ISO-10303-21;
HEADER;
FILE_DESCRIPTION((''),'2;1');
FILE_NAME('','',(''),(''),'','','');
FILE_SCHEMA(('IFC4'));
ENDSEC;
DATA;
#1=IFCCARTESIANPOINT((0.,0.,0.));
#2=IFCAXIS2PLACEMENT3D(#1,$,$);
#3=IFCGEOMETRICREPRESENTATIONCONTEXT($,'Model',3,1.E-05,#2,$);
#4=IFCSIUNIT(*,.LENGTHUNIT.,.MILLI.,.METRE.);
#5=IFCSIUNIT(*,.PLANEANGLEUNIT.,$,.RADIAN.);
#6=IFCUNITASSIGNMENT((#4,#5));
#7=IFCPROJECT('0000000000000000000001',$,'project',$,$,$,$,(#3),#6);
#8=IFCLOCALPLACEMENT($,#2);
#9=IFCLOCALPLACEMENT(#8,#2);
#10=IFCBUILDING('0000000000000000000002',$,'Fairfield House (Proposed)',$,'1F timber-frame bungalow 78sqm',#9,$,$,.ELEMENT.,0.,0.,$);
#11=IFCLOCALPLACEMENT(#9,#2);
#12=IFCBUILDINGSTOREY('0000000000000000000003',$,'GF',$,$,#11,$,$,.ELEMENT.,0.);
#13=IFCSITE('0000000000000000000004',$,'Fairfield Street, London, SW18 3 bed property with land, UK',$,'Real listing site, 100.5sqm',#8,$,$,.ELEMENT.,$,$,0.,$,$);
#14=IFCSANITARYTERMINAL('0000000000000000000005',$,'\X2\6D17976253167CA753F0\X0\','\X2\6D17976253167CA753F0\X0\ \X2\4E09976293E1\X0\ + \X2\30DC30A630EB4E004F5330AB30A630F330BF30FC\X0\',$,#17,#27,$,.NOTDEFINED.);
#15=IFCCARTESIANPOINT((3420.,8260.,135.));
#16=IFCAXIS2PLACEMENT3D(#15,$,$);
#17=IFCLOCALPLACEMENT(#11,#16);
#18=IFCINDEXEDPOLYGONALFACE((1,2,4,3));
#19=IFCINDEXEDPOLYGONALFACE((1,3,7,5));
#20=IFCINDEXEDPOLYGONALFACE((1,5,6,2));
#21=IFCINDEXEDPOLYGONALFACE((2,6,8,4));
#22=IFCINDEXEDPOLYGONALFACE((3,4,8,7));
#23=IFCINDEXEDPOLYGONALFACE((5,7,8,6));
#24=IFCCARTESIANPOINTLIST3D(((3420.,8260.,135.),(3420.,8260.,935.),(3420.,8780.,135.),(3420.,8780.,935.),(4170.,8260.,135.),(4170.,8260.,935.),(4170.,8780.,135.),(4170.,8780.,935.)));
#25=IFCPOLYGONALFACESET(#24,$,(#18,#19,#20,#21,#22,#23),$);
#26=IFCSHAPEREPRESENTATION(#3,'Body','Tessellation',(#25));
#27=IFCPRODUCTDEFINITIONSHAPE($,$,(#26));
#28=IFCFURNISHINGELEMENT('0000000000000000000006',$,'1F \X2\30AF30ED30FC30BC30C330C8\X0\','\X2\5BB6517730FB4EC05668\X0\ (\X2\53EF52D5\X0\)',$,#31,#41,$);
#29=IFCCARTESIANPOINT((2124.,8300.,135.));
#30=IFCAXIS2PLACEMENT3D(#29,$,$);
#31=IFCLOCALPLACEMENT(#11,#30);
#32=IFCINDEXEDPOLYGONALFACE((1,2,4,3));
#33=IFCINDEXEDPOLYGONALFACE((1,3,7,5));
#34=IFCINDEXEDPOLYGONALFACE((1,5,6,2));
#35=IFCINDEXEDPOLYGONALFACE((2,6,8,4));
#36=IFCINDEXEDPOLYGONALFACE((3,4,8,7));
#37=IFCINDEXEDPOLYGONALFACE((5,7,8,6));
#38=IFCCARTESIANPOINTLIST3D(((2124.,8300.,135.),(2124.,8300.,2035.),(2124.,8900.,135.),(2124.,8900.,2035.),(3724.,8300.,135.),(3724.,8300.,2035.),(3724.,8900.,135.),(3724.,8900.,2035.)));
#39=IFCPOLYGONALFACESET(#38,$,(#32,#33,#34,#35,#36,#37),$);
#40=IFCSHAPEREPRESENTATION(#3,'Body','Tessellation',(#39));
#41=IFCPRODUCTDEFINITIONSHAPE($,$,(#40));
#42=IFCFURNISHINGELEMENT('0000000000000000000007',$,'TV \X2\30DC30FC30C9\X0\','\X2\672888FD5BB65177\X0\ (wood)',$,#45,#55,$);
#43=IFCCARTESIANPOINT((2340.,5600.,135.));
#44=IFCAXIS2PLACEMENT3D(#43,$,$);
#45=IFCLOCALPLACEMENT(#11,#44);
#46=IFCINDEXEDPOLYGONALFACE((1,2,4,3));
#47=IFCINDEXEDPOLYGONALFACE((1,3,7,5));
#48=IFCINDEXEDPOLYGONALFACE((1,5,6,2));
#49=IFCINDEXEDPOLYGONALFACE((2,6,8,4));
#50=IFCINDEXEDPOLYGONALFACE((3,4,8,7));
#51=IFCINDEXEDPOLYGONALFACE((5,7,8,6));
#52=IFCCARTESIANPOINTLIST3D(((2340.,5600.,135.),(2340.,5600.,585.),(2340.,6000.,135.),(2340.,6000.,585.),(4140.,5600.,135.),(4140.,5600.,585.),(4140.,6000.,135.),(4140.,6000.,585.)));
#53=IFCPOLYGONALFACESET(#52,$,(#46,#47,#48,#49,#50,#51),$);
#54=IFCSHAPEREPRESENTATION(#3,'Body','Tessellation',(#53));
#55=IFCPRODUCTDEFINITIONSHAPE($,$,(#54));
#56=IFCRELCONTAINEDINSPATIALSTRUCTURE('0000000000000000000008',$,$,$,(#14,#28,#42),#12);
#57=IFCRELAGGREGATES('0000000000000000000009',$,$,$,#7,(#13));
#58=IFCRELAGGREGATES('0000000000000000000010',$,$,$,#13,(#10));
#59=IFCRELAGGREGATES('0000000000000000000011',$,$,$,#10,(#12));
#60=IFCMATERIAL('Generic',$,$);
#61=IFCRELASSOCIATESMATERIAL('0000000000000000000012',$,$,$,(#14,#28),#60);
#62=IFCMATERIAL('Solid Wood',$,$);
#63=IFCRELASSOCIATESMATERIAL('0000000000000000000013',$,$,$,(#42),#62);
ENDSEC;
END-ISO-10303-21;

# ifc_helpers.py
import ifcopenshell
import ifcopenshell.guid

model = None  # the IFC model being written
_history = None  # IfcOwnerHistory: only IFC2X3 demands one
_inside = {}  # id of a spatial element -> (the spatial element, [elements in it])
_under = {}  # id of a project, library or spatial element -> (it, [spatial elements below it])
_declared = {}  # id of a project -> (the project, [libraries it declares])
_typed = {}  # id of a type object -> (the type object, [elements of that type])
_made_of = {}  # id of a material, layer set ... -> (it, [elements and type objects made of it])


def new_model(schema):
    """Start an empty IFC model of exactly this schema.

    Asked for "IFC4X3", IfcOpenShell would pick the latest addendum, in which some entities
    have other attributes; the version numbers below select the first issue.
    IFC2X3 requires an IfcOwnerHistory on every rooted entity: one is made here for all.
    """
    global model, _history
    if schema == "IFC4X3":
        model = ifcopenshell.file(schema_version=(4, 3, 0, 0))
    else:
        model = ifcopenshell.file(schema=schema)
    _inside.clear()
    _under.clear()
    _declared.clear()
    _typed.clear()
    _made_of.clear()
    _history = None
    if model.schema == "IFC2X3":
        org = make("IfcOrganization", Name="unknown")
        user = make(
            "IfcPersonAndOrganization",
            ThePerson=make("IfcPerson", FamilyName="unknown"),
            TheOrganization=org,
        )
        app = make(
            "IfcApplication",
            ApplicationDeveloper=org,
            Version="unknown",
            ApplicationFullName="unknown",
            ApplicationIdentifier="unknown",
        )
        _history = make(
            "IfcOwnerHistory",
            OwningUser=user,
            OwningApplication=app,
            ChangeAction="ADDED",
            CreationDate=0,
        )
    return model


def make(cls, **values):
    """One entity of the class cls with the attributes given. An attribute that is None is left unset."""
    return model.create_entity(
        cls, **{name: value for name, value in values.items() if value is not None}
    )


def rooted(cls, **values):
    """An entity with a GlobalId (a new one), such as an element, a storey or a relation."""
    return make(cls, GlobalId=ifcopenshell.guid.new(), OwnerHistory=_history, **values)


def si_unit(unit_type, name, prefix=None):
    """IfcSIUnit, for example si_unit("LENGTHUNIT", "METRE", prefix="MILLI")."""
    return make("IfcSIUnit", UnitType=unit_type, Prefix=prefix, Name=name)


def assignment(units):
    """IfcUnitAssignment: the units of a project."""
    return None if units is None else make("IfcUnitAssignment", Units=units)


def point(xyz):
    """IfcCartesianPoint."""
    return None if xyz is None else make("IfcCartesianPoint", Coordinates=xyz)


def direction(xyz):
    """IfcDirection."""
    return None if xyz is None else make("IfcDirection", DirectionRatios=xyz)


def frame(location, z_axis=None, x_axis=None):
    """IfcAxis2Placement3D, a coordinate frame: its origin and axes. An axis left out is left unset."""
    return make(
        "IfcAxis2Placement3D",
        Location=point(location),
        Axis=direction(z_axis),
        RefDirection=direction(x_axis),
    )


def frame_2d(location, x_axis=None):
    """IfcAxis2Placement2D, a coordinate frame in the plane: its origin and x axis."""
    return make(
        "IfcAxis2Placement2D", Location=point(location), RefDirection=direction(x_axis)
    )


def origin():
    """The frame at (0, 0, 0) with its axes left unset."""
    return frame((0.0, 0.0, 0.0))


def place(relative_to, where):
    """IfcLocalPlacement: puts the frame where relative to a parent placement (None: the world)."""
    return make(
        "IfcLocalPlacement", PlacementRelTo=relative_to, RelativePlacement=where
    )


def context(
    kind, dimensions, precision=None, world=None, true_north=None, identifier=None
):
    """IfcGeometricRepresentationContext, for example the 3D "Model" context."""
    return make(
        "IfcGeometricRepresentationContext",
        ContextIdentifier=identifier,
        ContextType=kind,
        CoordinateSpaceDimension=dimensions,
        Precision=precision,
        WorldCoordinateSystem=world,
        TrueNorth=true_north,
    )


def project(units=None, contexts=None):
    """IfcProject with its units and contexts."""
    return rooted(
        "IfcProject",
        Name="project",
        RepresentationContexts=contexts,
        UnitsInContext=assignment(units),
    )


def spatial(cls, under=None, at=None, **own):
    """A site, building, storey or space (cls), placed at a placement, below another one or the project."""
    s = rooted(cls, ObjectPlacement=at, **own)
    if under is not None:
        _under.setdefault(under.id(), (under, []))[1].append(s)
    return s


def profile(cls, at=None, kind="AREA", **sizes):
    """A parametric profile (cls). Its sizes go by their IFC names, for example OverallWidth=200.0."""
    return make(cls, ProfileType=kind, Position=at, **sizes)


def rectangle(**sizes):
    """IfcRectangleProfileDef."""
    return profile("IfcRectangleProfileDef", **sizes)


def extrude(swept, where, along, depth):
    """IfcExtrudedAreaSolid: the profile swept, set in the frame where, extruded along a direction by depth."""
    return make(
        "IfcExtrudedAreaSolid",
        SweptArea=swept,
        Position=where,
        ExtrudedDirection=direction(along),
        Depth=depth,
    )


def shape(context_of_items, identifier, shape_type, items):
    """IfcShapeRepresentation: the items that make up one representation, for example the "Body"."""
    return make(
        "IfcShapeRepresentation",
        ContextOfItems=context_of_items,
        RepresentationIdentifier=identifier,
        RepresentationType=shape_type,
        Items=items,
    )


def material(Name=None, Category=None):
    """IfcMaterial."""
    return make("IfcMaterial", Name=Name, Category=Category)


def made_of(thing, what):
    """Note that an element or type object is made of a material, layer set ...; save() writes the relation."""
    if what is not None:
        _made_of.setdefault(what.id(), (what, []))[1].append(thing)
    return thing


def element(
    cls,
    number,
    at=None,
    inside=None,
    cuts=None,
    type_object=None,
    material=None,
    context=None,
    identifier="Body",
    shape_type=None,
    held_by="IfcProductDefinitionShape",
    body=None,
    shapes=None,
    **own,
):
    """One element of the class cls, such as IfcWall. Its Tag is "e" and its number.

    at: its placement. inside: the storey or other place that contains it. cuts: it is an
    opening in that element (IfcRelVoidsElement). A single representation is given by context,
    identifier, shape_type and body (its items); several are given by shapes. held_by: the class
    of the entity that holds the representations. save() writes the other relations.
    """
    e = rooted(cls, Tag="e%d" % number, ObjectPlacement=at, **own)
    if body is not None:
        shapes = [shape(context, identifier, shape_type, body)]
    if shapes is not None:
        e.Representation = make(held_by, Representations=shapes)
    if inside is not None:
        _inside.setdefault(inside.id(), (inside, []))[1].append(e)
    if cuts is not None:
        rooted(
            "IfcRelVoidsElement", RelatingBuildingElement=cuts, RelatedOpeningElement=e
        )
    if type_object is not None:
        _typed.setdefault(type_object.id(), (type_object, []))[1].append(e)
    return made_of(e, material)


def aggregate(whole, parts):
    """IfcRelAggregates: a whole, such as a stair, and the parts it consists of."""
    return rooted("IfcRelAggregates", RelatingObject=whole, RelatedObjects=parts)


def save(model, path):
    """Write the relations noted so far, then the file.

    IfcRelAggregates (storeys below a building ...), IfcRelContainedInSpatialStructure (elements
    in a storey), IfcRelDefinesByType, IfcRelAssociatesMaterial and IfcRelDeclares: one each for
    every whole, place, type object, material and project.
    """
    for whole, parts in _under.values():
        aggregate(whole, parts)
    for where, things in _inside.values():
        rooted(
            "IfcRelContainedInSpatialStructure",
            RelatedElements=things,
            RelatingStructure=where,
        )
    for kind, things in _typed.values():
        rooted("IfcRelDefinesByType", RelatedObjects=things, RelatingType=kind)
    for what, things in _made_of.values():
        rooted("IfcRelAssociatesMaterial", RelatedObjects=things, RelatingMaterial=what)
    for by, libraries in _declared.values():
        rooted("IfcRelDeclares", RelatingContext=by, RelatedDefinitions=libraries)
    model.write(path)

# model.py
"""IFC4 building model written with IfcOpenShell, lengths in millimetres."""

from ifc_helpers import new_model, si_unit, frame, frame_2d, origin, place, context, project, spatial, rectangle, extrude, material, element, save


model = new_model("IFC4")

# Units and contexts
model_context = context("Model", 3, precision=1e-05, world=origin())
ifc_project = project(units=[si_unit("LENGTHUNIT", "METRE", prefix="MILLI"), si_unit("PLANEANGLEUNIT", "RADIAN")], contexts=[model_context])

# Site, building, storey
site_placement = place(None, origin())
site = spatial("IfcSite", under=ifc_project, at=site_placement, Name="Fairfield Street, London, SW18 3 bed property with land, UK", ObjectType="Real listing site, 100.5sqm", CompositionType="ELEMENT", RefElevation=0.0)
building_placement = place(site_placement, origin())
building = spatial("IfcBuilding", under=site, at=building_placement, Name="Fairfield House (Proposed)", ObjectType="1F timber-frame bungalow 78sqm", CompositionType="ELEMENT", ElevationOfRefHeight=0.0, ElevationOfTerrain=0.0)
storey_placement = place(building_placement, origin())
storey = spatial("IfcBuildingStorey", under=building, at=storey_placement, Name="GF", CompositionType="ELEMENT", Elevation=0.0)

# Shared definitions
ifc_material_1 = material(Name="Solid Wood")

# Shared definitions
ifc_material_2 = material(Name="Generic")

# Sanitary terminal
sanitary_terminal_1_placement = place(storey_placement, frame((3420.0, 8260.0, 135.0)))
element("IfcSanitaryTerminal", 1, at=sanitary_terminal_1_placement, inside=storey, material=ifc_material_2, Name="洗面化粧台", Description="洗面化粧台 三面鏡 + ボウル一体カウンター", PredefinedType="NOTDEFINED", context=model_context, shape_type="SweptSolid", body=[
    extrude(rectangle(XDim=750.0, YDim=520.0, at=frame_2d((375.0, 260.0))), frame((3420.0, 8260.0, 135.0)), (0.0, 0.0, 1.0), 800.0),
])

# Furnishing elements
furnishing_1_placement = place(storey_placement, frame((2124.0, 8300.0, 135.0)))
element("IfcFurnishingElement", 2, at=furnishing_1_placement, inside=storey, material=ifc_material_2, Name="1F クローゼット", Description="家具・什器 (可動)", context=model_context, shape_type="SweptSolid", body=[
    extrude(rectangle(XDim=1600.0, YDim=600.0, at=frame_2d((800.0, 300.0))), frame((2124.0, 8300.0, 135.0)), (0.0, 0.0, 1.0), 1900.0),
])
furnishing_2_placement = place(storey_placement, frame((2340.0, 5600.0, 135.0)))
element("IfcFurnishingElement", 3, at=furnishing_2_placement, inside=storey, material=ifc_material_1, Name="TV ボード", Description="木製家具 (wood)", context=model_context, shape_type="SweptSolid", body=[
    extrude(rectangle(XDim=1800.0, YDim=400.0, at=frame_2d((900.0, 200.0))), frame((2340.0, 5600.0, 135.0)), (0.0, 0.0, 1.0), 450.0),
])

save(model, "model.ifc")
